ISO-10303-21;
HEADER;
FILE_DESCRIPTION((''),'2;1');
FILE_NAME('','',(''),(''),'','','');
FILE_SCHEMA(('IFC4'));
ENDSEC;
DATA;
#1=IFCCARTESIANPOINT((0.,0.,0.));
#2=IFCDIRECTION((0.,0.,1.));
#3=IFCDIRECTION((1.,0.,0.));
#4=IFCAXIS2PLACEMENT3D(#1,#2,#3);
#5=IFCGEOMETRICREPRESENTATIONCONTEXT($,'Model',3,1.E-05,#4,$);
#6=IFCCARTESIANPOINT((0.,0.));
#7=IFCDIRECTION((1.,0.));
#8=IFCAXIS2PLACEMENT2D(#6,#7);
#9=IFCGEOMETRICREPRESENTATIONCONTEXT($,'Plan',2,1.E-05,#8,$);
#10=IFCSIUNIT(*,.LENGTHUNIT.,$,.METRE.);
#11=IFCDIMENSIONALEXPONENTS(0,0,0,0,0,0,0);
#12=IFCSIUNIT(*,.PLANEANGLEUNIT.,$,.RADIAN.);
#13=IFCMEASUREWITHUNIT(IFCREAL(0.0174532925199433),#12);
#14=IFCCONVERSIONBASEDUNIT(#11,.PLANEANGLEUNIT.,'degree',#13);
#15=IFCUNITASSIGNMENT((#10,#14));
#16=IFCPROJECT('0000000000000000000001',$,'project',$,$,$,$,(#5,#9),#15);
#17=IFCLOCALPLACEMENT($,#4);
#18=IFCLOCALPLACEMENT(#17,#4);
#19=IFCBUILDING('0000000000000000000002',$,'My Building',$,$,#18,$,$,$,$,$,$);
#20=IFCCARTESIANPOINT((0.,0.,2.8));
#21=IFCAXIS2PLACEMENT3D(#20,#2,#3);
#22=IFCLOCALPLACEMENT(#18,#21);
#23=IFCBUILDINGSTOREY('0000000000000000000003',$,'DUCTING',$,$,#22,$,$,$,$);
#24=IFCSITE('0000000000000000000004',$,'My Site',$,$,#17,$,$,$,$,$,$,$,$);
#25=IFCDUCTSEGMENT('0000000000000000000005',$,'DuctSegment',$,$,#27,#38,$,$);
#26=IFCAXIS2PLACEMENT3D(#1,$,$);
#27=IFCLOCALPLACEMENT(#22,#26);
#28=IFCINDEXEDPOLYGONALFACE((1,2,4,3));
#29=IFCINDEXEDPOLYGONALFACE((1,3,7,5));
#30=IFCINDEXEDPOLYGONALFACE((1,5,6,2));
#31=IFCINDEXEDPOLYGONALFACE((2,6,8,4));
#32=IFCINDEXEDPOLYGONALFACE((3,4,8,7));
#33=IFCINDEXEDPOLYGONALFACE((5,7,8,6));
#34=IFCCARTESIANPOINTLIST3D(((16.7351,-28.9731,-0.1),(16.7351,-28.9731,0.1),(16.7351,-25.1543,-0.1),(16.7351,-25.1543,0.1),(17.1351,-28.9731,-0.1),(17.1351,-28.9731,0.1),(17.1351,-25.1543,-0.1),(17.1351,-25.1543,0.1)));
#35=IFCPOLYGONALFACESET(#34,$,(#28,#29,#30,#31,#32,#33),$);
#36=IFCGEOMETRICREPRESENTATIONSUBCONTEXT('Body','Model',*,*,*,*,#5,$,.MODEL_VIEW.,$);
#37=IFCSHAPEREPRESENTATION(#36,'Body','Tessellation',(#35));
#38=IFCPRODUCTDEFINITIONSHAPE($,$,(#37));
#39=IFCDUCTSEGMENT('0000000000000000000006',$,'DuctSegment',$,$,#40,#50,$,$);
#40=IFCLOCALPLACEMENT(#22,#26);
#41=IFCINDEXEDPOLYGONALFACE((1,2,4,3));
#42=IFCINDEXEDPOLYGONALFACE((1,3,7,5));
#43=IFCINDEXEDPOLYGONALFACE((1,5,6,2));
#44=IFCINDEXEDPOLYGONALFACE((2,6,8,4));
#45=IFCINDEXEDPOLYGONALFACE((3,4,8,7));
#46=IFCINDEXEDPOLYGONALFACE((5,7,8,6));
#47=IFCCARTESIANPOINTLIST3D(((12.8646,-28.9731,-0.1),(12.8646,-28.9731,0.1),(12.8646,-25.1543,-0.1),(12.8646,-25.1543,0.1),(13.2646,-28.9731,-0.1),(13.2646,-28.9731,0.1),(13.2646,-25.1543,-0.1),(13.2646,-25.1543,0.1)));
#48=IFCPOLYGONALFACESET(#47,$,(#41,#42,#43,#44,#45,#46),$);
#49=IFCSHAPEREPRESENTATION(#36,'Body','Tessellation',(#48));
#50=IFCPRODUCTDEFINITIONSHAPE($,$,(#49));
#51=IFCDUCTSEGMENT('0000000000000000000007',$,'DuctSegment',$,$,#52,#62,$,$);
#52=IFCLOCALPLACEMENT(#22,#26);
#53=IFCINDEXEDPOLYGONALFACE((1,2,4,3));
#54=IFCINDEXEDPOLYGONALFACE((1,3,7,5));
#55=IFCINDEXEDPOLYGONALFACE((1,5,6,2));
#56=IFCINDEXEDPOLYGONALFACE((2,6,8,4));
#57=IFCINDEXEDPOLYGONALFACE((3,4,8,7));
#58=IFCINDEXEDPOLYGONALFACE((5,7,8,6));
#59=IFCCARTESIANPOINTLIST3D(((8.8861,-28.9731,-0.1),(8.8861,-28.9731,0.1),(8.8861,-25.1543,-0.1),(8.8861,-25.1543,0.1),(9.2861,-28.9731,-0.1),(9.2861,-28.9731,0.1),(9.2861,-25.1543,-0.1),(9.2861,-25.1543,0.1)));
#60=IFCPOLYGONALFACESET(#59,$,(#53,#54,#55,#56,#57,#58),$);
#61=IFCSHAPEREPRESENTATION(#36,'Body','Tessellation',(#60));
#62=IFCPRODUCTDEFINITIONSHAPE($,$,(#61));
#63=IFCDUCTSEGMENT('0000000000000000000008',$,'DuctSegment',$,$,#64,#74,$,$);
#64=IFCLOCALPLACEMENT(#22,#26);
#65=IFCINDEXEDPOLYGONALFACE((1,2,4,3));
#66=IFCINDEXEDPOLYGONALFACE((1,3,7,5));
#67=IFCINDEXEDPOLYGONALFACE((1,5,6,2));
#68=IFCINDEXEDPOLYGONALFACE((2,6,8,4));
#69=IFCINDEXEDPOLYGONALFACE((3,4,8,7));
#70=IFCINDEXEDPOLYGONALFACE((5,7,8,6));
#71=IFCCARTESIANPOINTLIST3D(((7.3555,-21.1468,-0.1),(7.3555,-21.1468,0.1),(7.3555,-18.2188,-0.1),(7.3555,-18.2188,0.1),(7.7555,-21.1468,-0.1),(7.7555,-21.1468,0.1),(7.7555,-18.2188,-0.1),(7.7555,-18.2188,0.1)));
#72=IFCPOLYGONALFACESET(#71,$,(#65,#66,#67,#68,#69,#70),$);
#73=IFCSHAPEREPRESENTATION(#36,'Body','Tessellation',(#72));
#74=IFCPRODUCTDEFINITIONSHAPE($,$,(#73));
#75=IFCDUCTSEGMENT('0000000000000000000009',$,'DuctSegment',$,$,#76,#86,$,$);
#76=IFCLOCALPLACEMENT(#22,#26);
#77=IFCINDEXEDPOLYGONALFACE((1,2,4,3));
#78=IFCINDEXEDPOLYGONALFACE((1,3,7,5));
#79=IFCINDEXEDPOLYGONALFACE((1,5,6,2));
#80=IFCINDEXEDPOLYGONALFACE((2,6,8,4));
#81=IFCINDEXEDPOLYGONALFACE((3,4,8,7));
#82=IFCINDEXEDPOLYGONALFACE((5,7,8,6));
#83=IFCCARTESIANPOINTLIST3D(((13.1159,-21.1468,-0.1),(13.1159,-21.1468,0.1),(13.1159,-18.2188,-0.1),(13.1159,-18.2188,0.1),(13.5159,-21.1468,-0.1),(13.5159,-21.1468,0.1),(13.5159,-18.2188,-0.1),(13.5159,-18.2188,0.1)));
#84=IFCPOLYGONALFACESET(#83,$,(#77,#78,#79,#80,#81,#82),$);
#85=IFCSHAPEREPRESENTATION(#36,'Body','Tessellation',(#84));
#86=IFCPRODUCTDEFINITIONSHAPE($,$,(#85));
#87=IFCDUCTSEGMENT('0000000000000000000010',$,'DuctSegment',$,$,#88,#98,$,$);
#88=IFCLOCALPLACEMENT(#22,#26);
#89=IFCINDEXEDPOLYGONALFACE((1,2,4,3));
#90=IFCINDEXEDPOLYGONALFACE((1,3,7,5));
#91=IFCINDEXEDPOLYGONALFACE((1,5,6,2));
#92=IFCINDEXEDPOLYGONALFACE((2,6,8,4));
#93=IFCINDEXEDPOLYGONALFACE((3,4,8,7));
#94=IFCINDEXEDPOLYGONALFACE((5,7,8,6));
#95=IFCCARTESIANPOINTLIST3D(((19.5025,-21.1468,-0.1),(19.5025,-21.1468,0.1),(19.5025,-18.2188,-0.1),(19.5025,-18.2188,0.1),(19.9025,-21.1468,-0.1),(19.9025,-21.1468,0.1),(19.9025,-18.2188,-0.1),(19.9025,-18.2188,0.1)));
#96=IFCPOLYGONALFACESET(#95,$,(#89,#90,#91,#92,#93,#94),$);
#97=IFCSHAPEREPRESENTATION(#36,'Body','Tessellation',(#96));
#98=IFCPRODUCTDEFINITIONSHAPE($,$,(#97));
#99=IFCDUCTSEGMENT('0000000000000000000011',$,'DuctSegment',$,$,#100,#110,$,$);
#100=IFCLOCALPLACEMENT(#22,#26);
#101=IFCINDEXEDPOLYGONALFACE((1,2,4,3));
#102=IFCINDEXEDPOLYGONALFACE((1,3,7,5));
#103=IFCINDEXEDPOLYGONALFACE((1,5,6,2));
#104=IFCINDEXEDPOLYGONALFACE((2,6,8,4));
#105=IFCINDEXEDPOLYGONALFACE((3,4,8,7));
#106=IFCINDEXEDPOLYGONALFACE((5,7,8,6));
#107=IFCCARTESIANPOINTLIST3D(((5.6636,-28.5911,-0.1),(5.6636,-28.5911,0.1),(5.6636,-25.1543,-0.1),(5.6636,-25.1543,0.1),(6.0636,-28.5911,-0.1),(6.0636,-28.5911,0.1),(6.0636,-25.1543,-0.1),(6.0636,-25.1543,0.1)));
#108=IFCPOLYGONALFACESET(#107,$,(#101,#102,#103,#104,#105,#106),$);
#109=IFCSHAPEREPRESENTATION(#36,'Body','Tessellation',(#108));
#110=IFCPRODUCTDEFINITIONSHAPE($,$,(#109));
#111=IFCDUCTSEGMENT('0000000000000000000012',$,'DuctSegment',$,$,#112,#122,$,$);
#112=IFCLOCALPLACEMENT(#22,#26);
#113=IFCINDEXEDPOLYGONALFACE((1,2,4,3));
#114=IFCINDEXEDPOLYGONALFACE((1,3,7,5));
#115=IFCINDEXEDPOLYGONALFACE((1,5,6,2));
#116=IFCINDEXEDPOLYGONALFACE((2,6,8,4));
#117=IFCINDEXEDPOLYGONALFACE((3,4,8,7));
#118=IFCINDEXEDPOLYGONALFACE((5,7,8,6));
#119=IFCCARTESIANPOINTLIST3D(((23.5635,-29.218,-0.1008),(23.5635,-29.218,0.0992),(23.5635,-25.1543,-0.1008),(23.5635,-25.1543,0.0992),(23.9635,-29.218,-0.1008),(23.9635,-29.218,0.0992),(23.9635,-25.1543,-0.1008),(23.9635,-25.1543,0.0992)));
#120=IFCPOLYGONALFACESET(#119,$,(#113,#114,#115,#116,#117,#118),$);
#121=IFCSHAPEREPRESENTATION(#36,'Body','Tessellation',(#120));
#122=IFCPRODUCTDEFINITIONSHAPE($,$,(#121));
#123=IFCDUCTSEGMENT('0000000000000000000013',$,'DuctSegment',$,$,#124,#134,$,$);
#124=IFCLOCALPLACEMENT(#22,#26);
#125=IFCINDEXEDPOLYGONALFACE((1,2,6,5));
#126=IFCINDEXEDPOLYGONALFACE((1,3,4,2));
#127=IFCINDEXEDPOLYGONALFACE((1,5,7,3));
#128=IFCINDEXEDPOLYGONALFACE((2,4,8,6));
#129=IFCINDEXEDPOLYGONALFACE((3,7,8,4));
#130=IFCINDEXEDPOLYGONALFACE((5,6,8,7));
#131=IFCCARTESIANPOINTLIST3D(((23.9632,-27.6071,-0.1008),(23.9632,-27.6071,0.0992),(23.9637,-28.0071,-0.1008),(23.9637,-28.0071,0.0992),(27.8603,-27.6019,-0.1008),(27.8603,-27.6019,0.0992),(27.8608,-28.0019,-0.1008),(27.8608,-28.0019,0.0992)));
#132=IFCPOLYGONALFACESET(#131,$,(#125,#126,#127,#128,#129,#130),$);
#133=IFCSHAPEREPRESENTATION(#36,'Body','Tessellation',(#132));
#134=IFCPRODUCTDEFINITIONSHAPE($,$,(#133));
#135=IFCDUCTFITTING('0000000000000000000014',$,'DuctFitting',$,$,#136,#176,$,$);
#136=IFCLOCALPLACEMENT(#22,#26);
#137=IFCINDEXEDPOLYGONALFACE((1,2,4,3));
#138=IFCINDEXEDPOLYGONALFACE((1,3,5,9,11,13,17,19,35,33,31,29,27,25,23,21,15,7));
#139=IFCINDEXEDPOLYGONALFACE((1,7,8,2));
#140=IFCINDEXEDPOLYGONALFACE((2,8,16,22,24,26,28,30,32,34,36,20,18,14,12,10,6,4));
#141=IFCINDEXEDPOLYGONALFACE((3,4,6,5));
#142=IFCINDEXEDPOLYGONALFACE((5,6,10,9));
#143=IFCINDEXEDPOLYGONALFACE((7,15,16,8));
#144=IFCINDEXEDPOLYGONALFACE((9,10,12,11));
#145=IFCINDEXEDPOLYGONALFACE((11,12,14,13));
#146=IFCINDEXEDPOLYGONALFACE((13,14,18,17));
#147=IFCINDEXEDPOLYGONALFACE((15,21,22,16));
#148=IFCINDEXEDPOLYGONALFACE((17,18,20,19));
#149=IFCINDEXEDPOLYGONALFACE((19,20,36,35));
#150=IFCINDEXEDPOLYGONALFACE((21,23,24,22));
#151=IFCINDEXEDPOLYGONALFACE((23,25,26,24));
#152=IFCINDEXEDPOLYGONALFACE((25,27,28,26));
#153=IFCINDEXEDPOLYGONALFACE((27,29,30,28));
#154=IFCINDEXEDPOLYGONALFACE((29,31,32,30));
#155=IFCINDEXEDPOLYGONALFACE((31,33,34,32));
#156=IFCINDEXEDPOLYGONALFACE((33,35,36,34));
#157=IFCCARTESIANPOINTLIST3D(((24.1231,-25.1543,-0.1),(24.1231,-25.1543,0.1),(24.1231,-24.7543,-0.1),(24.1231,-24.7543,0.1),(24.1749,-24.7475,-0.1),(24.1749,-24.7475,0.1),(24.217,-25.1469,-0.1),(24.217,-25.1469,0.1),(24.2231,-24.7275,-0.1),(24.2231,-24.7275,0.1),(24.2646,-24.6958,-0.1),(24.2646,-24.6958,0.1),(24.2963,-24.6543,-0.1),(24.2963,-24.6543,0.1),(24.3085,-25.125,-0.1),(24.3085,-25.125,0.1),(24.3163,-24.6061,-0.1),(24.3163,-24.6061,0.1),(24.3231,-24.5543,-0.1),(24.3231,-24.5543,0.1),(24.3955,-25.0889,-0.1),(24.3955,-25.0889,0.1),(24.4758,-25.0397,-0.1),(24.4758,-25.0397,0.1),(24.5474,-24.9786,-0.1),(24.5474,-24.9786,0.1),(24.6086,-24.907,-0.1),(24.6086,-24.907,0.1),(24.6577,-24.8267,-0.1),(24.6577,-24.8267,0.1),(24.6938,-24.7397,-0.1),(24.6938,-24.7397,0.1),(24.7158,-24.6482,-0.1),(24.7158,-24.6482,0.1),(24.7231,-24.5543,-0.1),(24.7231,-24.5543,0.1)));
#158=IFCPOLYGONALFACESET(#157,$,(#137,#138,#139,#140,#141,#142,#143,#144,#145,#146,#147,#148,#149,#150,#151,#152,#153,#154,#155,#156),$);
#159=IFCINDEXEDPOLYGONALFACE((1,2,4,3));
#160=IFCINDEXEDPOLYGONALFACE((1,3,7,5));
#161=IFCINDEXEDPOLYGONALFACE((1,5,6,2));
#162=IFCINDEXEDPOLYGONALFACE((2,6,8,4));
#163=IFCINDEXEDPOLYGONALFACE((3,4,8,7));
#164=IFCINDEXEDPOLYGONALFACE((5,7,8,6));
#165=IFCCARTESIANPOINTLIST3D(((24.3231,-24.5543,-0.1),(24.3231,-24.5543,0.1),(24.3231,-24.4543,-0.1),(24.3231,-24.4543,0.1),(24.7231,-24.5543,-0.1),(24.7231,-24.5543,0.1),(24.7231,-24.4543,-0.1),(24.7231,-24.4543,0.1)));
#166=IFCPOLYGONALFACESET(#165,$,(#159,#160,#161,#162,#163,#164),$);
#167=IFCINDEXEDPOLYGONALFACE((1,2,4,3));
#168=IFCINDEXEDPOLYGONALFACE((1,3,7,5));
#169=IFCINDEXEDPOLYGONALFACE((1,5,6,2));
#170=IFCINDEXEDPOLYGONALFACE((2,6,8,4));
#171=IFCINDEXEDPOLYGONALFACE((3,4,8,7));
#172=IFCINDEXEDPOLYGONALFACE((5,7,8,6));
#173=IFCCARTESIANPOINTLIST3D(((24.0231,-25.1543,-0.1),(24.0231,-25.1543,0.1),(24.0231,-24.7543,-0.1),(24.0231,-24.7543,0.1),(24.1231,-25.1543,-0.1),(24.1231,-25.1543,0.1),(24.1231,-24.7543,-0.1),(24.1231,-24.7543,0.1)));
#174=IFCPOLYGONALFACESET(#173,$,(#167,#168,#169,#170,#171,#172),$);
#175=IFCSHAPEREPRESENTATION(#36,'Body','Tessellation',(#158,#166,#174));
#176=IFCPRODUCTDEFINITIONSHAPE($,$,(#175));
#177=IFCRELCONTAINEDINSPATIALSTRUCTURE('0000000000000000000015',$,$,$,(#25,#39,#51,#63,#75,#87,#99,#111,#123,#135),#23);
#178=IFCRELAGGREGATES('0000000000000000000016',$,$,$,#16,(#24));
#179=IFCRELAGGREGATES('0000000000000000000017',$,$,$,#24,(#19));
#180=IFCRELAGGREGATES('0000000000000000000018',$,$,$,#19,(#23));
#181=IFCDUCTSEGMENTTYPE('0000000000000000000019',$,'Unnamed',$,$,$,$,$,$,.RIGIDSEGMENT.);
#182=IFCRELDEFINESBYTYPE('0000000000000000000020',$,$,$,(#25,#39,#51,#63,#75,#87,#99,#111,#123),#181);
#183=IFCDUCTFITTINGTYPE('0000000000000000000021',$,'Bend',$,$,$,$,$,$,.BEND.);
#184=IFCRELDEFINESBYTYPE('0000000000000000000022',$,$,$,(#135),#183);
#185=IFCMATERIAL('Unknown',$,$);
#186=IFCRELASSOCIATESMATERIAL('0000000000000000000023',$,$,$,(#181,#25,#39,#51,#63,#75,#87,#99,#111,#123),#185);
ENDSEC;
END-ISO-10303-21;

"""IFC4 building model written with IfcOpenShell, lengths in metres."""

from ifc_helpers import new_model, entity, si_unit, converted_unit, frame, origin_with_axes, origin_2d_with_axis, place, context, subcontext, project, spatial, line, arc, indexed_curve, rectangle, outline, extrude, source, transform, mapped, material, material_profile, profile_set, profile_usage, type_object, type_shapes, element, save


model = new_model("IFC4")

# Units and contexts
model_context = context("Model", 3, precision=1e-05, world=origin_with_axes())
plan_context = context("Plan", 2, precision=1e-05, world=origin_2d_with_axis())
body_context = subcontext(model_context, "Body", "Model", "MODEL_VIEW")
ifc_project = project(units=[si_unit("LENGTHUNIT", "METRE"), converted_unit("PLANEANGLEUNIT", "degree", entity("IfcReal", 0.0174532925199433), si_unit("PLANEANGLEUNIT", "RADIAN"), dimensions=[0, 0, 0, 0, 0, 0, 0])], contexts=[model_context, plan_context])

# Site, building, storey
site_placement = place(None, origin_with_axes())
site = spatial("IfcSite", under=ifc_project, at=site_placement, Name="My Site")
building_placement = place(site_placement, origin_with_axes())
building = spatial("IfcBuilding", under=site, at=building_placement, Name="My Building")
storey_placement = place(building_placement, frame((0.0, 0.0, 2.8), z_axis=(0.0, 0.0, 1.0), x_axis=(1.0, 0.0, 0.0)))
storey = spatial("IfcBuildingStorey", under=building, at=storey_placement, Name="DUCTING")

# Duct segments
ifc_material = material(Name="Unknown")
ifc_material_profile = material_profile(ifc_material, rectangle(XDim=0.4, YDim=0.2))
ifc_profile_set = profile_set([ifc_material_profile])
duct_segment_type = type_object("IfcDuctSegmentType", Name="Unnamed", PredefinedType="RIGIDSEGMENT", material=ifc_profile_set)
ifc_profile_usage_1 = profile_usage(ifc_profile_set, cardinal=5)
duct_segment_1_placement = place(storey_placement, frame((16.9351, -25.1543, 0.0), z_axis=(0.0, -1.0, 0.0), x_axis=(1.0, 0.0, 0.0)))
element("IfcDuctSegment", 1, at=duct_segment_1_placement, inside=storey, type_object=duct_segment_type, material=ifc_profile_usage_1, Name="DuctSegment", context=body_context, shape_type="SweptSolid", body=[
    extrude(rectangle(XDim=0.4, YDim=0.2), origin_with_axes(), (0.0, 0.0, 1.0), 3.8188),
])
ifc_profile_usage_2 = profile_usage(ifc_profile_set, cardinal=5)
duct_segment_2_placement = place(storey_placement, frame((13.0646, -25.1543, 0.0), z_axis=(0.0, -1.0, 0.0), x_axis=(1.0, 0.0, 0.0)))
element("IfcDuctSegment", 2, at=duct_segment_2_placement, inside=storey, type_object=duct_segment_type, material=ifc_profile_usage_2, Name="DuctSegment", context=body_context, shape_type="SweptSolid", body=[
    extrude(rectangle(XDim=0.4, YDim=0.2), origin_with_axes(), (0.0, 0.0, 1.0), 3.8188),
])
ifc_profile_usage_3 = profile_usage(ifc_profile_set, cardinal=5)
duct_segment_3_placement = place(storey_placement, frame((9.0861, -25.1543, 0.0), z_axis=(0.0, -1.0, 0.0), x_axis=(1.0, 0.0, 0.0)))
element("IfcDuctSegment", 3, at=duct_segment_3_placement, inside=storey, type_object=duct_segment_type, material=ifc_profile_usage_3, Name="DuctSegment", context=body_context, shape_type="SweptSolid", body=[
    extrude(rectangle(XDim=0.4, YDim=0.2), origin_with_axes(), (0.0, 0.0, 1.0), 3.8188),
])
ifc_profile_usage_4 = profile_usage(ifc_profile_set, cardinal=5)
duct_segment_4_placement = place(storey_placement, frame((7.5555, -18.2188, 0.0), z_axis=(0.0, -1.0, 0.0), x_axis=(1.0, 0.0, 0.0)))
element("IfcDuctSegment", 4, at=duct_segment_4_placement, inside=storey, type_object=duct_segment_type, material=ifc_profile_usage_4, Name="DuctSegment", context=body_context, shape_type="SweptSolid", body=[
    extrude(rectangle(XDim=0.4, YDim=0.2), origin_with_axes(), (0.0, 0.0, 1.0), 2.928),
])
ifc_profile_usage_5 = profile_usage(ifc_profile_set, cardinal=5)
duct_segment_5_placement = place(storey_placement, frame((13.3159, -18.2188, 0.0), z_axis=(0.0, -1.0, 0.0), x_axis=(1.0, 0.0, 0.0)))
element("IfcDuctSegment", 5, at=duct_segment_5_placement, inside=storey, type_object=duct_segment_type, material=ifc_profile_usage_5, Name="DuctSegment", context=body_context, shape_type="SweptSolid", body=[
    extrude(rectangle(XDim=0.4, YDim=0.2), origin_with_axes(), (0.0, 0.0, 1.0), 2.928),
])
ifc_profile_usage_6 = profile_usage(ifc_profile_set, cardinal=5)
duct_segment_6_placement = place(storey_placement, frame((19.7025, -18.2188, 0.0), z_axis=(0.0, -1.0, 0.0), x_axis=(1.0, 0.0, 0.0)))
element("IfcDuctSegment", 6, at=duct_segment_6_placement, inside=storey, type_object=duct_segment_type, material=ifc_profile_usage_6, Name="DuctSegment", context=body_context, shape_type="SweptSolid", body=[
    extrude(rectangle(XDim=0.4, YDim=0.2), origin_with_axes(), (0.0, 0.0, 1.0), 2.928),
])
ifc_profile_usage_7 = profile_usage(ifc_profile_set, cardinal=5)
duct_segment_7_placement = place(storey_placement, frame((5.8636, -25.1543, 0.0), z_axis=(0.0, -1.0, 0.0), x_axis=(1.0, 0.0, 0.0)))
element("IfcDuctSegment", 7, at=duct_segment_7_placement, inside=storey, type_object=duct_segment_type, material=ifc_profile_usage_7, Name="DuctSegment", context=body_context, shape_type="SweptSolid", body=[
    extrude(rectangle(XDim=0.4, YDim=0.2), origin_with_axes(), (0.0, 0.0, 1.0), 3.4367),
])
ifc_profile_usage_8 = profile_usage(ifc_profile_set, cardinal=5)
duct_segment_8_placement = place(storey_placement, frame((23.7635, -25.1543, -0.0008), z_axis=(0.0, -1.0, 0.0), x_axis=(1.0, 0.0, 0.0)))
element("IfcDuctSegment", 8, at=duct_segment_8_placement, inside=storey, type_object=duct_segment_type, material=ifc_profile_usage_8, Name="DuctSegment", context=body_context, shape_type="SweptSolid", body=[
    extrude(rectangle(XDim=0.4, YDim=0.2), origin_with_axes(), (0.0, 0.0, 1.0), 4.0636),
])
ifc_profile_usage_9 = profile_usage(ifc_profile_set, cardinal=5)
duct_segment_9_placement = place(storey_placement, frame((23.9635, -27.8071, -0.0008), z_axis=(0.999999, 0.001336, 0.0), x_axis=(-0.001336, 0.999999, 0.0)))
element("IfcDuctSegment", 9, at=duct_segment_9_placement, inside=storey, type_object=duct_segment_type, material=ifc_profile_usage_9, Name="DuctSegment", context=body_context, shape_type="SweptSolid", body=[
    extrude(rectangle(XDim=0.4, YDim=0.2), origin_with_axes(), (0.0, 0.0, 1.0), 3.8971),
])

# Duct fitting
duct_fitting_type_1 = type_object("IfcDuctFittingType", Name="Bend", PredefinedType="BEND")
shared_shape_1 = source(origin_with_axes(), body_context, "Body", "SweptSolid", [
    extrude(outline(indexed_curve([(-0.2, 0.0), (-0.2586, 0.1414), (-0.4, 0.2), (-0.4, 0.6), (0.0243, 0.4243), (0.2, 0.0)], segments=[arc(1, 2, 3), line(3, 4), arc(4, 5, 6), line(6, 1)])), frame((0.0, -0.1, 0.1), z_axis=(0.0, -1.0, 0.0), x_axis=(1.0, 0.0, 0.0)), (0.0, 0.0, -1.0), 0.2),
    extrude(rectangle(XDim=0.4, YDim=0.2), origin_with_axes(), (0.0, 0.0, 1.0), 0.1),
    extrude(rectangle(XDim=0.4, YDim=0.2), frame((-0.4, 0.0, 0.5), z_axis=(-1.0, 0.0, -0.000007), x_axis=(0.000007, 0.0, -1.0)), (0.0, 0.0, 1.0), 0.1),
])
type_shapes(duct_fitting_type_1, [shared_shape_1])
for number, where, z_axis, x_axis, name in (
    (10, (24.5231, -24.4543, 0.0), (0.000006, -1.0, 0.0), (1.0, 0.000006, 0.0), "DuctFitting"),
):
    element("IfcDuctFitting", number, at=place(storey_placement, frame(where, z_axis=z_axis, x_axis=x_axis)), inside=storey, type_object=duct_fitting_type_1, Name=name, context=body_context, shape_type="MappedRepresentation", body=[
        mapped(shared_shape_1, transform((0.0, 0.0, 0.0), x_axis=(1.0, 0.0, 0.0), y_axis=(0.0, 1.0, 0.0), z_axis=(0.0, 0.0, 1.0), scale=1.0)),
    ])

save(model, "model.ifc")
